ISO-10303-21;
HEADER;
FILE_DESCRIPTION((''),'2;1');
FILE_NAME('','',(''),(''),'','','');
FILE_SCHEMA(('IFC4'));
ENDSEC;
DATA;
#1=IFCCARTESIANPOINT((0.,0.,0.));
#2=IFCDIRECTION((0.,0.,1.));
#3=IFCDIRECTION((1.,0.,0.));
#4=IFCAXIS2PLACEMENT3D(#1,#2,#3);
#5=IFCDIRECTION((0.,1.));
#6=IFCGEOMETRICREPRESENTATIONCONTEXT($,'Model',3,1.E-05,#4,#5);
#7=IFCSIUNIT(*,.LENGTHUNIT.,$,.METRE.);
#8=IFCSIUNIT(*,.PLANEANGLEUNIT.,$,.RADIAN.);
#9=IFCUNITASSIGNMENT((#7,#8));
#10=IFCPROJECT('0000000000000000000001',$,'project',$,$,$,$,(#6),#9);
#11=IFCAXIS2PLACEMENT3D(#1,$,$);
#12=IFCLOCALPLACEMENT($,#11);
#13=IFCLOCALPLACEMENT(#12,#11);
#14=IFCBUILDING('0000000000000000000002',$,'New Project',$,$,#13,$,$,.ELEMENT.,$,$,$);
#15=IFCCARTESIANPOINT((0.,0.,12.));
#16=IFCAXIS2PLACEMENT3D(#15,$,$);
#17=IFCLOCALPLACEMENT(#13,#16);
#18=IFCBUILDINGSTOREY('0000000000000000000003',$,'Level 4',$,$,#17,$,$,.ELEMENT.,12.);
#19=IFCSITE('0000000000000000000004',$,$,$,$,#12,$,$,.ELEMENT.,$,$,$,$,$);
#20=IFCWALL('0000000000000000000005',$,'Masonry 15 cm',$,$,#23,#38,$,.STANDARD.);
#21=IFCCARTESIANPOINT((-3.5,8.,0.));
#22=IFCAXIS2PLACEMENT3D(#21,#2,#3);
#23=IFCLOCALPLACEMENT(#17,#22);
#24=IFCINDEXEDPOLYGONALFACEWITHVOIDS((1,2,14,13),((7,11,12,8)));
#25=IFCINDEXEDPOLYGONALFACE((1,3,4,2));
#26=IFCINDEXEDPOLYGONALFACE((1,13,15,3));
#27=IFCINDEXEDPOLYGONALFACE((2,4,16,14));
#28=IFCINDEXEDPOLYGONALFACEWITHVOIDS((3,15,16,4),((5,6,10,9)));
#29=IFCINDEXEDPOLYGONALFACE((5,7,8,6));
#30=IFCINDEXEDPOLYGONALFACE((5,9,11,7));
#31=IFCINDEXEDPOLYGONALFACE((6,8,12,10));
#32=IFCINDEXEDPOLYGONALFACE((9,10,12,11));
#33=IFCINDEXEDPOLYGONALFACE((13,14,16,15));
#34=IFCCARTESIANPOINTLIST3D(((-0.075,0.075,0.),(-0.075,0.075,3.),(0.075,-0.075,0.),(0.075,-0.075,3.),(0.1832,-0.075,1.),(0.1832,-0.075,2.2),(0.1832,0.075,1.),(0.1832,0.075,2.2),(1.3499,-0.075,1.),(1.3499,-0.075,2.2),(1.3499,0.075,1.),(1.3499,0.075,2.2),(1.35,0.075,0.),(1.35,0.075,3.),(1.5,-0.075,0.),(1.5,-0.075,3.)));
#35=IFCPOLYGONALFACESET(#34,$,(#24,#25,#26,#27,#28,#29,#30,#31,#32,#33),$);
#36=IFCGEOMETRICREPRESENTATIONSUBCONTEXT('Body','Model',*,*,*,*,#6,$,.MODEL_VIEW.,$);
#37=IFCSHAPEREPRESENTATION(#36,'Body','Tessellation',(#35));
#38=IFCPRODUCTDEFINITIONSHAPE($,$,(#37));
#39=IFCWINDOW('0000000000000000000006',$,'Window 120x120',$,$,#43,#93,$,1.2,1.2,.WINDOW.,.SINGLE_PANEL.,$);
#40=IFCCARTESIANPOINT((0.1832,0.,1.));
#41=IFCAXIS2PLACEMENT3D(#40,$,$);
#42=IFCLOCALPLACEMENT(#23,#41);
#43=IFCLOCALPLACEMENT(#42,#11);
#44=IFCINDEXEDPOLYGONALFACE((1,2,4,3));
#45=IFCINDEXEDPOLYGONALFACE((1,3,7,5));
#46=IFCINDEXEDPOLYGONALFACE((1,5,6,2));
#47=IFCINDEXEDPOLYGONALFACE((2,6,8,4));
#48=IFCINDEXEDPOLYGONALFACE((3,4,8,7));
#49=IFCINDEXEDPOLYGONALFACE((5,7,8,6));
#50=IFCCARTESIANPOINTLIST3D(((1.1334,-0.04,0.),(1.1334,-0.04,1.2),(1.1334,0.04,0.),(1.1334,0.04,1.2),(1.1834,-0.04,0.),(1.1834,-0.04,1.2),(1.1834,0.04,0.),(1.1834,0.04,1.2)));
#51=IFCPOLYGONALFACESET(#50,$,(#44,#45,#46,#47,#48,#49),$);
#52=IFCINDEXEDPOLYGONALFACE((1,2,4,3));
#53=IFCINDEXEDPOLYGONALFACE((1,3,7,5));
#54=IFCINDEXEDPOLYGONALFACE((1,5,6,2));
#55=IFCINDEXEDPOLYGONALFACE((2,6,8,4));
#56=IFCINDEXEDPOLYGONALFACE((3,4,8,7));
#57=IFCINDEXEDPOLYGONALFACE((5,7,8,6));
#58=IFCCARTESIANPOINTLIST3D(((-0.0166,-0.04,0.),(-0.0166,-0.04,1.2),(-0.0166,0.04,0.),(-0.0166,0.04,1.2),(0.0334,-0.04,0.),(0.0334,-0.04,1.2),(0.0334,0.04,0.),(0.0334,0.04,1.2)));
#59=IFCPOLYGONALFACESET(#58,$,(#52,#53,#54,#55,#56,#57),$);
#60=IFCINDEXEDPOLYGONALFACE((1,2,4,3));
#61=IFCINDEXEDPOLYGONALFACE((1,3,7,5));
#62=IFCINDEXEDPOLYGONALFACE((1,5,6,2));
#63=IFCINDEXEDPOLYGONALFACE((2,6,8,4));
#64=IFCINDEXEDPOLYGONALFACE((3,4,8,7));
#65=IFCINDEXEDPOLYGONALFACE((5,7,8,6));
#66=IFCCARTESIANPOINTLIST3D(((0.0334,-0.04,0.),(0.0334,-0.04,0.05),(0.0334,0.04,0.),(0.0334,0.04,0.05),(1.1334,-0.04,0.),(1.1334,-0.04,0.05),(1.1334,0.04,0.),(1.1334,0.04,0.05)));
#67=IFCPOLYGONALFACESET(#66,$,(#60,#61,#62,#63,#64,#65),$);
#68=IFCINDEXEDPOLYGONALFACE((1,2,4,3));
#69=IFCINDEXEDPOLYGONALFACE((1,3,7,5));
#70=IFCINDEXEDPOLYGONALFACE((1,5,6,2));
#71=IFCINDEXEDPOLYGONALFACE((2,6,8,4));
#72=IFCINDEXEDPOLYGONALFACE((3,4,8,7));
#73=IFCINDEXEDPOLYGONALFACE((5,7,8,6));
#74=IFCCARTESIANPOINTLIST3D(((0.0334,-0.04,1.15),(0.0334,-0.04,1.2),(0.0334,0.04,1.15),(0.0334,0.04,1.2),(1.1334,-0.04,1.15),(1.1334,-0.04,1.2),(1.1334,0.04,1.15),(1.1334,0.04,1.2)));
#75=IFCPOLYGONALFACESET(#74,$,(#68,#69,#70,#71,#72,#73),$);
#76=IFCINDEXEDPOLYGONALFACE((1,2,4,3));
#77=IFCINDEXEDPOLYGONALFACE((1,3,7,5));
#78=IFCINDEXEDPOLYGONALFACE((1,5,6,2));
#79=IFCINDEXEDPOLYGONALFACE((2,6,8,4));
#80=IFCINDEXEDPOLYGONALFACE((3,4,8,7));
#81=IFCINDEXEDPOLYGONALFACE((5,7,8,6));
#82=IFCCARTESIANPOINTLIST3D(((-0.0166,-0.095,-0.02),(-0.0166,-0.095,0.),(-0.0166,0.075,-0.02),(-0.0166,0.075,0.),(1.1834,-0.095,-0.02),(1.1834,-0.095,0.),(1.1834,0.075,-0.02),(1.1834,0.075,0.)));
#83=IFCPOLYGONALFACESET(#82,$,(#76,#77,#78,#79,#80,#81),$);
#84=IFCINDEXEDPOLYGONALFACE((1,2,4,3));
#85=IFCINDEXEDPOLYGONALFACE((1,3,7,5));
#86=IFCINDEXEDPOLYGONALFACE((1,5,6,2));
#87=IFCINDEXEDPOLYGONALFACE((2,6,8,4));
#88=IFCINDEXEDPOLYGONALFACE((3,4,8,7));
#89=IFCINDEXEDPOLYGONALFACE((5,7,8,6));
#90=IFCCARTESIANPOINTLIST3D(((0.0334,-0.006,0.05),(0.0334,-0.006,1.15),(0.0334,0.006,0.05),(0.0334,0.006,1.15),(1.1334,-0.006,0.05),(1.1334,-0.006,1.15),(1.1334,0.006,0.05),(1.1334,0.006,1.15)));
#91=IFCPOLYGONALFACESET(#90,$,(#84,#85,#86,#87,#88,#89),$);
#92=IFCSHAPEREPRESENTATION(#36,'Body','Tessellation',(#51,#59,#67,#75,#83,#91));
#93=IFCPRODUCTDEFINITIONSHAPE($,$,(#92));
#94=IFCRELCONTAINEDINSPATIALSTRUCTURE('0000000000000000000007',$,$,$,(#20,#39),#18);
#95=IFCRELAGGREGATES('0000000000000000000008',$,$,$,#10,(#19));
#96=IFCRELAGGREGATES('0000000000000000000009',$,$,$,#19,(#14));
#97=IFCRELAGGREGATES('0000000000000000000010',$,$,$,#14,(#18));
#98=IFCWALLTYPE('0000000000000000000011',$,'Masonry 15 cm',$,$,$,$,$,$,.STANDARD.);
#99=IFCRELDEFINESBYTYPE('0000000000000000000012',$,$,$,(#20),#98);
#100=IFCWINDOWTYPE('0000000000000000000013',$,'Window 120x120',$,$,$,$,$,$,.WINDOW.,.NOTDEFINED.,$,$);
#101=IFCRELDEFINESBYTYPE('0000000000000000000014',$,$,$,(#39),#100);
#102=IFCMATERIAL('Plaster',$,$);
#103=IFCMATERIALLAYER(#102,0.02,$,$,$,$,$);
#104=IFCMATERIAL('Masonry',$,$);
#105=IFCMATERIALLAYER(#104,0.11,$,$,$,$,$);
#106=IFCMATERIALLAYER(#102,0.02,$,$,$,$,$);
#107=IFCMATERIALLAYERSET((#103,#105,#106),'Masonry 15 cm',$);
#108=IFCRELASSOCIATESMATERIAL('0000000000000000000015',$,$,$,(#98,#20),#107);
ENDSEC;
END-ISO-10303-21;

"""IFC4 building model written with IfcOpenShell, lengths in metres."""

from ifc_helpers import new_model, si_unit, direction, frame, frame_2d, origin, origin_with_axes, place, context, subcontext, project, spatial, polyline, rectangle, outline, extrude, material, layer, layer_set, layer_usage, type_object, element, fill, save


model = new_model("IFC4")

# Units and contexts
model_context = context("Model", 3, precision=1e-05, world=origin_with_axes(), true_north=direction((0.0, 1.0)))
body_context = subcontext(model_context, "Body", "Model", "MODEL_VIEW")
ifc_project = project(units=[si_unit("LENGTHUNIT", "METRE"), si_unit("PLANEANGLEUNIT", "RADIAN")], contexts=[model_context])

# Site, building, storey
site_placement = place(None, origin())
site = spatial("IfcSite", under=ifc_project, at=site_placement, CompositionType="ELEMENT")
building_placement = place(site_placement, origin())
building = spatial("IfcBuilding", under=site, at=building_placement, Name="New Project", CompositionType="ELEMENT")
storey_placement = place(building_placement, frame((0.0, 0.0, 12.0)))
storey = spatial("IfcBuildingStorey", under=building, at=storey_placement, Name="Level 4", CompositionType="ELEMENT", Elevation=12.0)

# Shared definitions
ifc_material_1 = material(Name="Plaster")
ifc_layer_1 = layer(ifc_material_1, 0.02)
ifc_material_2 = material(Name="Masonry")
ifc_layer_2 = layer(ifc_material_2, 0.11)
ifc_layer_3 = layer(ifc_material_1, 0.02)
ifc_layer_set_1 = layer_set([ifc_layer_1, ifc_layer_2, ifc_layer_3], Name="Masonry 15 cm")
ifc_layer_usage_1 = layer_usage(ifc_layer_set_1, "AXIS2", "NEGATIVE", 0.075)
wall_type = type_object("IfcWallType", Name="Masonry 15 cm", PredefinedType="STANDARD", material=ifc_layer_set_1)
window_type = type_object("IfcWindowType", Name="Window 120x120", PartitioningType="NOTDEFINED", PredefinedType="WINDOW")

# Wall, opening, window
wall_1_placement = place(storey_placement, frame((-3.5, 8.0, 0.0), z_axis=(0.0, 0.0, 1.0), x_axis=(1.0, 0.0, 0.0)))
wall_1 = element("IfcWall", 1, at=wall_1_placement, inside=storey, type_object=wall_type, material=ifc_layer_usage_1, Name="Masonry 15 cm", PredefinedType="STANDARD", context=body_context, shape_type="SweptSolid", body=[
    extrude(outline(polyline([(0.075, -0.075), (1.5, -0.075), (1.35, 0.075), (-0.075, 0.075), (0.075, -0.075)])), origin(), (0.0, 0.0, 1.0), 3.0),
])
opening_1_placement = place(wall_1_placement, frame((0.1832, 0.0, 1.0)))
opening_1 = element("IfcOpeningElement", 2, at=opening_1_placement, cuts=wall_1, PredefinedType="OPENING", context=body_context, shape_type="SweptSolid", body=[
    extrude(rectangle(XDim=1.1667, YDim=0.25, at=frame_2d((0.5834, 0.0))), origin(), (0.0, 0.0, 1.0), 1.2),
])
window_1_placement = place(opening_1_placement, origin())
window_1 = element("IfcWindow", 3, at=window_1_placement, inside=storey, type_object=window_type, Name="Window 120x120", OverallHeight=1.2, OverallWidth=1.2, PartitioningType="SINGLE_PANEL", PredefinedType="WINDOW", context=body_context, shape_type="SweptSolid", body=[
    extrude(outline(polyline([(1.1834, 0.04), (1.1334, 0.04), (1.1334, -0.04), (1.1834, -0.04), (1.1834, 0.04)])), origin(), (0.0, 0.0, 1.0), 1.2),
    extrude(outline(polyline([(0.0334, 0.04), (-0.0166, 0.04), (-0.0166, -0.04), (0.0334, -0.04), (0.0334, 0.04)])), origin(), (0.0, 0.0, 1.0), 1.2),
    extrude(outline(polyline([(1.1334, 0.04), (0.0334, 0.04), (0.0334, -0.04), (1.1334, -0.04), (1.1334, 0.04)])), origin(), (0.0, 0.0, 1.0), 0.05),
    extrude(outline(polyline([(1.1334, 0.04), (0.0334, 0.04), (0.0334, -0.04), (1.1334, -0.04), (1.1334, 0.04)])), frame((0.0, 0.0, 1.15)), (0.0, 0.0, 1.0), 0.05),
    extrude(outline(polyline([(1.1834, 0.075), (-0.0166, 0.075), (-0.0166, -0.095), (1.1834, -0.095), (1.1834, 0.075)])), frame((0.0, 0.0, -0.02)), (0.0, 0.0, 1.0), 0.02),
    extrude(outline(polyline([(1.1334, 0.006), (0.0334, 0.006), (0.0334, -0.006), (1.1334, -0.006), (1.1334, 0.006)])), frame((0.0, 0.0, 0.05)), (0.0, 0.0, 1.0), 1.1),
])
fill(opening_1, window_1)

save(model, "model.ifc")
